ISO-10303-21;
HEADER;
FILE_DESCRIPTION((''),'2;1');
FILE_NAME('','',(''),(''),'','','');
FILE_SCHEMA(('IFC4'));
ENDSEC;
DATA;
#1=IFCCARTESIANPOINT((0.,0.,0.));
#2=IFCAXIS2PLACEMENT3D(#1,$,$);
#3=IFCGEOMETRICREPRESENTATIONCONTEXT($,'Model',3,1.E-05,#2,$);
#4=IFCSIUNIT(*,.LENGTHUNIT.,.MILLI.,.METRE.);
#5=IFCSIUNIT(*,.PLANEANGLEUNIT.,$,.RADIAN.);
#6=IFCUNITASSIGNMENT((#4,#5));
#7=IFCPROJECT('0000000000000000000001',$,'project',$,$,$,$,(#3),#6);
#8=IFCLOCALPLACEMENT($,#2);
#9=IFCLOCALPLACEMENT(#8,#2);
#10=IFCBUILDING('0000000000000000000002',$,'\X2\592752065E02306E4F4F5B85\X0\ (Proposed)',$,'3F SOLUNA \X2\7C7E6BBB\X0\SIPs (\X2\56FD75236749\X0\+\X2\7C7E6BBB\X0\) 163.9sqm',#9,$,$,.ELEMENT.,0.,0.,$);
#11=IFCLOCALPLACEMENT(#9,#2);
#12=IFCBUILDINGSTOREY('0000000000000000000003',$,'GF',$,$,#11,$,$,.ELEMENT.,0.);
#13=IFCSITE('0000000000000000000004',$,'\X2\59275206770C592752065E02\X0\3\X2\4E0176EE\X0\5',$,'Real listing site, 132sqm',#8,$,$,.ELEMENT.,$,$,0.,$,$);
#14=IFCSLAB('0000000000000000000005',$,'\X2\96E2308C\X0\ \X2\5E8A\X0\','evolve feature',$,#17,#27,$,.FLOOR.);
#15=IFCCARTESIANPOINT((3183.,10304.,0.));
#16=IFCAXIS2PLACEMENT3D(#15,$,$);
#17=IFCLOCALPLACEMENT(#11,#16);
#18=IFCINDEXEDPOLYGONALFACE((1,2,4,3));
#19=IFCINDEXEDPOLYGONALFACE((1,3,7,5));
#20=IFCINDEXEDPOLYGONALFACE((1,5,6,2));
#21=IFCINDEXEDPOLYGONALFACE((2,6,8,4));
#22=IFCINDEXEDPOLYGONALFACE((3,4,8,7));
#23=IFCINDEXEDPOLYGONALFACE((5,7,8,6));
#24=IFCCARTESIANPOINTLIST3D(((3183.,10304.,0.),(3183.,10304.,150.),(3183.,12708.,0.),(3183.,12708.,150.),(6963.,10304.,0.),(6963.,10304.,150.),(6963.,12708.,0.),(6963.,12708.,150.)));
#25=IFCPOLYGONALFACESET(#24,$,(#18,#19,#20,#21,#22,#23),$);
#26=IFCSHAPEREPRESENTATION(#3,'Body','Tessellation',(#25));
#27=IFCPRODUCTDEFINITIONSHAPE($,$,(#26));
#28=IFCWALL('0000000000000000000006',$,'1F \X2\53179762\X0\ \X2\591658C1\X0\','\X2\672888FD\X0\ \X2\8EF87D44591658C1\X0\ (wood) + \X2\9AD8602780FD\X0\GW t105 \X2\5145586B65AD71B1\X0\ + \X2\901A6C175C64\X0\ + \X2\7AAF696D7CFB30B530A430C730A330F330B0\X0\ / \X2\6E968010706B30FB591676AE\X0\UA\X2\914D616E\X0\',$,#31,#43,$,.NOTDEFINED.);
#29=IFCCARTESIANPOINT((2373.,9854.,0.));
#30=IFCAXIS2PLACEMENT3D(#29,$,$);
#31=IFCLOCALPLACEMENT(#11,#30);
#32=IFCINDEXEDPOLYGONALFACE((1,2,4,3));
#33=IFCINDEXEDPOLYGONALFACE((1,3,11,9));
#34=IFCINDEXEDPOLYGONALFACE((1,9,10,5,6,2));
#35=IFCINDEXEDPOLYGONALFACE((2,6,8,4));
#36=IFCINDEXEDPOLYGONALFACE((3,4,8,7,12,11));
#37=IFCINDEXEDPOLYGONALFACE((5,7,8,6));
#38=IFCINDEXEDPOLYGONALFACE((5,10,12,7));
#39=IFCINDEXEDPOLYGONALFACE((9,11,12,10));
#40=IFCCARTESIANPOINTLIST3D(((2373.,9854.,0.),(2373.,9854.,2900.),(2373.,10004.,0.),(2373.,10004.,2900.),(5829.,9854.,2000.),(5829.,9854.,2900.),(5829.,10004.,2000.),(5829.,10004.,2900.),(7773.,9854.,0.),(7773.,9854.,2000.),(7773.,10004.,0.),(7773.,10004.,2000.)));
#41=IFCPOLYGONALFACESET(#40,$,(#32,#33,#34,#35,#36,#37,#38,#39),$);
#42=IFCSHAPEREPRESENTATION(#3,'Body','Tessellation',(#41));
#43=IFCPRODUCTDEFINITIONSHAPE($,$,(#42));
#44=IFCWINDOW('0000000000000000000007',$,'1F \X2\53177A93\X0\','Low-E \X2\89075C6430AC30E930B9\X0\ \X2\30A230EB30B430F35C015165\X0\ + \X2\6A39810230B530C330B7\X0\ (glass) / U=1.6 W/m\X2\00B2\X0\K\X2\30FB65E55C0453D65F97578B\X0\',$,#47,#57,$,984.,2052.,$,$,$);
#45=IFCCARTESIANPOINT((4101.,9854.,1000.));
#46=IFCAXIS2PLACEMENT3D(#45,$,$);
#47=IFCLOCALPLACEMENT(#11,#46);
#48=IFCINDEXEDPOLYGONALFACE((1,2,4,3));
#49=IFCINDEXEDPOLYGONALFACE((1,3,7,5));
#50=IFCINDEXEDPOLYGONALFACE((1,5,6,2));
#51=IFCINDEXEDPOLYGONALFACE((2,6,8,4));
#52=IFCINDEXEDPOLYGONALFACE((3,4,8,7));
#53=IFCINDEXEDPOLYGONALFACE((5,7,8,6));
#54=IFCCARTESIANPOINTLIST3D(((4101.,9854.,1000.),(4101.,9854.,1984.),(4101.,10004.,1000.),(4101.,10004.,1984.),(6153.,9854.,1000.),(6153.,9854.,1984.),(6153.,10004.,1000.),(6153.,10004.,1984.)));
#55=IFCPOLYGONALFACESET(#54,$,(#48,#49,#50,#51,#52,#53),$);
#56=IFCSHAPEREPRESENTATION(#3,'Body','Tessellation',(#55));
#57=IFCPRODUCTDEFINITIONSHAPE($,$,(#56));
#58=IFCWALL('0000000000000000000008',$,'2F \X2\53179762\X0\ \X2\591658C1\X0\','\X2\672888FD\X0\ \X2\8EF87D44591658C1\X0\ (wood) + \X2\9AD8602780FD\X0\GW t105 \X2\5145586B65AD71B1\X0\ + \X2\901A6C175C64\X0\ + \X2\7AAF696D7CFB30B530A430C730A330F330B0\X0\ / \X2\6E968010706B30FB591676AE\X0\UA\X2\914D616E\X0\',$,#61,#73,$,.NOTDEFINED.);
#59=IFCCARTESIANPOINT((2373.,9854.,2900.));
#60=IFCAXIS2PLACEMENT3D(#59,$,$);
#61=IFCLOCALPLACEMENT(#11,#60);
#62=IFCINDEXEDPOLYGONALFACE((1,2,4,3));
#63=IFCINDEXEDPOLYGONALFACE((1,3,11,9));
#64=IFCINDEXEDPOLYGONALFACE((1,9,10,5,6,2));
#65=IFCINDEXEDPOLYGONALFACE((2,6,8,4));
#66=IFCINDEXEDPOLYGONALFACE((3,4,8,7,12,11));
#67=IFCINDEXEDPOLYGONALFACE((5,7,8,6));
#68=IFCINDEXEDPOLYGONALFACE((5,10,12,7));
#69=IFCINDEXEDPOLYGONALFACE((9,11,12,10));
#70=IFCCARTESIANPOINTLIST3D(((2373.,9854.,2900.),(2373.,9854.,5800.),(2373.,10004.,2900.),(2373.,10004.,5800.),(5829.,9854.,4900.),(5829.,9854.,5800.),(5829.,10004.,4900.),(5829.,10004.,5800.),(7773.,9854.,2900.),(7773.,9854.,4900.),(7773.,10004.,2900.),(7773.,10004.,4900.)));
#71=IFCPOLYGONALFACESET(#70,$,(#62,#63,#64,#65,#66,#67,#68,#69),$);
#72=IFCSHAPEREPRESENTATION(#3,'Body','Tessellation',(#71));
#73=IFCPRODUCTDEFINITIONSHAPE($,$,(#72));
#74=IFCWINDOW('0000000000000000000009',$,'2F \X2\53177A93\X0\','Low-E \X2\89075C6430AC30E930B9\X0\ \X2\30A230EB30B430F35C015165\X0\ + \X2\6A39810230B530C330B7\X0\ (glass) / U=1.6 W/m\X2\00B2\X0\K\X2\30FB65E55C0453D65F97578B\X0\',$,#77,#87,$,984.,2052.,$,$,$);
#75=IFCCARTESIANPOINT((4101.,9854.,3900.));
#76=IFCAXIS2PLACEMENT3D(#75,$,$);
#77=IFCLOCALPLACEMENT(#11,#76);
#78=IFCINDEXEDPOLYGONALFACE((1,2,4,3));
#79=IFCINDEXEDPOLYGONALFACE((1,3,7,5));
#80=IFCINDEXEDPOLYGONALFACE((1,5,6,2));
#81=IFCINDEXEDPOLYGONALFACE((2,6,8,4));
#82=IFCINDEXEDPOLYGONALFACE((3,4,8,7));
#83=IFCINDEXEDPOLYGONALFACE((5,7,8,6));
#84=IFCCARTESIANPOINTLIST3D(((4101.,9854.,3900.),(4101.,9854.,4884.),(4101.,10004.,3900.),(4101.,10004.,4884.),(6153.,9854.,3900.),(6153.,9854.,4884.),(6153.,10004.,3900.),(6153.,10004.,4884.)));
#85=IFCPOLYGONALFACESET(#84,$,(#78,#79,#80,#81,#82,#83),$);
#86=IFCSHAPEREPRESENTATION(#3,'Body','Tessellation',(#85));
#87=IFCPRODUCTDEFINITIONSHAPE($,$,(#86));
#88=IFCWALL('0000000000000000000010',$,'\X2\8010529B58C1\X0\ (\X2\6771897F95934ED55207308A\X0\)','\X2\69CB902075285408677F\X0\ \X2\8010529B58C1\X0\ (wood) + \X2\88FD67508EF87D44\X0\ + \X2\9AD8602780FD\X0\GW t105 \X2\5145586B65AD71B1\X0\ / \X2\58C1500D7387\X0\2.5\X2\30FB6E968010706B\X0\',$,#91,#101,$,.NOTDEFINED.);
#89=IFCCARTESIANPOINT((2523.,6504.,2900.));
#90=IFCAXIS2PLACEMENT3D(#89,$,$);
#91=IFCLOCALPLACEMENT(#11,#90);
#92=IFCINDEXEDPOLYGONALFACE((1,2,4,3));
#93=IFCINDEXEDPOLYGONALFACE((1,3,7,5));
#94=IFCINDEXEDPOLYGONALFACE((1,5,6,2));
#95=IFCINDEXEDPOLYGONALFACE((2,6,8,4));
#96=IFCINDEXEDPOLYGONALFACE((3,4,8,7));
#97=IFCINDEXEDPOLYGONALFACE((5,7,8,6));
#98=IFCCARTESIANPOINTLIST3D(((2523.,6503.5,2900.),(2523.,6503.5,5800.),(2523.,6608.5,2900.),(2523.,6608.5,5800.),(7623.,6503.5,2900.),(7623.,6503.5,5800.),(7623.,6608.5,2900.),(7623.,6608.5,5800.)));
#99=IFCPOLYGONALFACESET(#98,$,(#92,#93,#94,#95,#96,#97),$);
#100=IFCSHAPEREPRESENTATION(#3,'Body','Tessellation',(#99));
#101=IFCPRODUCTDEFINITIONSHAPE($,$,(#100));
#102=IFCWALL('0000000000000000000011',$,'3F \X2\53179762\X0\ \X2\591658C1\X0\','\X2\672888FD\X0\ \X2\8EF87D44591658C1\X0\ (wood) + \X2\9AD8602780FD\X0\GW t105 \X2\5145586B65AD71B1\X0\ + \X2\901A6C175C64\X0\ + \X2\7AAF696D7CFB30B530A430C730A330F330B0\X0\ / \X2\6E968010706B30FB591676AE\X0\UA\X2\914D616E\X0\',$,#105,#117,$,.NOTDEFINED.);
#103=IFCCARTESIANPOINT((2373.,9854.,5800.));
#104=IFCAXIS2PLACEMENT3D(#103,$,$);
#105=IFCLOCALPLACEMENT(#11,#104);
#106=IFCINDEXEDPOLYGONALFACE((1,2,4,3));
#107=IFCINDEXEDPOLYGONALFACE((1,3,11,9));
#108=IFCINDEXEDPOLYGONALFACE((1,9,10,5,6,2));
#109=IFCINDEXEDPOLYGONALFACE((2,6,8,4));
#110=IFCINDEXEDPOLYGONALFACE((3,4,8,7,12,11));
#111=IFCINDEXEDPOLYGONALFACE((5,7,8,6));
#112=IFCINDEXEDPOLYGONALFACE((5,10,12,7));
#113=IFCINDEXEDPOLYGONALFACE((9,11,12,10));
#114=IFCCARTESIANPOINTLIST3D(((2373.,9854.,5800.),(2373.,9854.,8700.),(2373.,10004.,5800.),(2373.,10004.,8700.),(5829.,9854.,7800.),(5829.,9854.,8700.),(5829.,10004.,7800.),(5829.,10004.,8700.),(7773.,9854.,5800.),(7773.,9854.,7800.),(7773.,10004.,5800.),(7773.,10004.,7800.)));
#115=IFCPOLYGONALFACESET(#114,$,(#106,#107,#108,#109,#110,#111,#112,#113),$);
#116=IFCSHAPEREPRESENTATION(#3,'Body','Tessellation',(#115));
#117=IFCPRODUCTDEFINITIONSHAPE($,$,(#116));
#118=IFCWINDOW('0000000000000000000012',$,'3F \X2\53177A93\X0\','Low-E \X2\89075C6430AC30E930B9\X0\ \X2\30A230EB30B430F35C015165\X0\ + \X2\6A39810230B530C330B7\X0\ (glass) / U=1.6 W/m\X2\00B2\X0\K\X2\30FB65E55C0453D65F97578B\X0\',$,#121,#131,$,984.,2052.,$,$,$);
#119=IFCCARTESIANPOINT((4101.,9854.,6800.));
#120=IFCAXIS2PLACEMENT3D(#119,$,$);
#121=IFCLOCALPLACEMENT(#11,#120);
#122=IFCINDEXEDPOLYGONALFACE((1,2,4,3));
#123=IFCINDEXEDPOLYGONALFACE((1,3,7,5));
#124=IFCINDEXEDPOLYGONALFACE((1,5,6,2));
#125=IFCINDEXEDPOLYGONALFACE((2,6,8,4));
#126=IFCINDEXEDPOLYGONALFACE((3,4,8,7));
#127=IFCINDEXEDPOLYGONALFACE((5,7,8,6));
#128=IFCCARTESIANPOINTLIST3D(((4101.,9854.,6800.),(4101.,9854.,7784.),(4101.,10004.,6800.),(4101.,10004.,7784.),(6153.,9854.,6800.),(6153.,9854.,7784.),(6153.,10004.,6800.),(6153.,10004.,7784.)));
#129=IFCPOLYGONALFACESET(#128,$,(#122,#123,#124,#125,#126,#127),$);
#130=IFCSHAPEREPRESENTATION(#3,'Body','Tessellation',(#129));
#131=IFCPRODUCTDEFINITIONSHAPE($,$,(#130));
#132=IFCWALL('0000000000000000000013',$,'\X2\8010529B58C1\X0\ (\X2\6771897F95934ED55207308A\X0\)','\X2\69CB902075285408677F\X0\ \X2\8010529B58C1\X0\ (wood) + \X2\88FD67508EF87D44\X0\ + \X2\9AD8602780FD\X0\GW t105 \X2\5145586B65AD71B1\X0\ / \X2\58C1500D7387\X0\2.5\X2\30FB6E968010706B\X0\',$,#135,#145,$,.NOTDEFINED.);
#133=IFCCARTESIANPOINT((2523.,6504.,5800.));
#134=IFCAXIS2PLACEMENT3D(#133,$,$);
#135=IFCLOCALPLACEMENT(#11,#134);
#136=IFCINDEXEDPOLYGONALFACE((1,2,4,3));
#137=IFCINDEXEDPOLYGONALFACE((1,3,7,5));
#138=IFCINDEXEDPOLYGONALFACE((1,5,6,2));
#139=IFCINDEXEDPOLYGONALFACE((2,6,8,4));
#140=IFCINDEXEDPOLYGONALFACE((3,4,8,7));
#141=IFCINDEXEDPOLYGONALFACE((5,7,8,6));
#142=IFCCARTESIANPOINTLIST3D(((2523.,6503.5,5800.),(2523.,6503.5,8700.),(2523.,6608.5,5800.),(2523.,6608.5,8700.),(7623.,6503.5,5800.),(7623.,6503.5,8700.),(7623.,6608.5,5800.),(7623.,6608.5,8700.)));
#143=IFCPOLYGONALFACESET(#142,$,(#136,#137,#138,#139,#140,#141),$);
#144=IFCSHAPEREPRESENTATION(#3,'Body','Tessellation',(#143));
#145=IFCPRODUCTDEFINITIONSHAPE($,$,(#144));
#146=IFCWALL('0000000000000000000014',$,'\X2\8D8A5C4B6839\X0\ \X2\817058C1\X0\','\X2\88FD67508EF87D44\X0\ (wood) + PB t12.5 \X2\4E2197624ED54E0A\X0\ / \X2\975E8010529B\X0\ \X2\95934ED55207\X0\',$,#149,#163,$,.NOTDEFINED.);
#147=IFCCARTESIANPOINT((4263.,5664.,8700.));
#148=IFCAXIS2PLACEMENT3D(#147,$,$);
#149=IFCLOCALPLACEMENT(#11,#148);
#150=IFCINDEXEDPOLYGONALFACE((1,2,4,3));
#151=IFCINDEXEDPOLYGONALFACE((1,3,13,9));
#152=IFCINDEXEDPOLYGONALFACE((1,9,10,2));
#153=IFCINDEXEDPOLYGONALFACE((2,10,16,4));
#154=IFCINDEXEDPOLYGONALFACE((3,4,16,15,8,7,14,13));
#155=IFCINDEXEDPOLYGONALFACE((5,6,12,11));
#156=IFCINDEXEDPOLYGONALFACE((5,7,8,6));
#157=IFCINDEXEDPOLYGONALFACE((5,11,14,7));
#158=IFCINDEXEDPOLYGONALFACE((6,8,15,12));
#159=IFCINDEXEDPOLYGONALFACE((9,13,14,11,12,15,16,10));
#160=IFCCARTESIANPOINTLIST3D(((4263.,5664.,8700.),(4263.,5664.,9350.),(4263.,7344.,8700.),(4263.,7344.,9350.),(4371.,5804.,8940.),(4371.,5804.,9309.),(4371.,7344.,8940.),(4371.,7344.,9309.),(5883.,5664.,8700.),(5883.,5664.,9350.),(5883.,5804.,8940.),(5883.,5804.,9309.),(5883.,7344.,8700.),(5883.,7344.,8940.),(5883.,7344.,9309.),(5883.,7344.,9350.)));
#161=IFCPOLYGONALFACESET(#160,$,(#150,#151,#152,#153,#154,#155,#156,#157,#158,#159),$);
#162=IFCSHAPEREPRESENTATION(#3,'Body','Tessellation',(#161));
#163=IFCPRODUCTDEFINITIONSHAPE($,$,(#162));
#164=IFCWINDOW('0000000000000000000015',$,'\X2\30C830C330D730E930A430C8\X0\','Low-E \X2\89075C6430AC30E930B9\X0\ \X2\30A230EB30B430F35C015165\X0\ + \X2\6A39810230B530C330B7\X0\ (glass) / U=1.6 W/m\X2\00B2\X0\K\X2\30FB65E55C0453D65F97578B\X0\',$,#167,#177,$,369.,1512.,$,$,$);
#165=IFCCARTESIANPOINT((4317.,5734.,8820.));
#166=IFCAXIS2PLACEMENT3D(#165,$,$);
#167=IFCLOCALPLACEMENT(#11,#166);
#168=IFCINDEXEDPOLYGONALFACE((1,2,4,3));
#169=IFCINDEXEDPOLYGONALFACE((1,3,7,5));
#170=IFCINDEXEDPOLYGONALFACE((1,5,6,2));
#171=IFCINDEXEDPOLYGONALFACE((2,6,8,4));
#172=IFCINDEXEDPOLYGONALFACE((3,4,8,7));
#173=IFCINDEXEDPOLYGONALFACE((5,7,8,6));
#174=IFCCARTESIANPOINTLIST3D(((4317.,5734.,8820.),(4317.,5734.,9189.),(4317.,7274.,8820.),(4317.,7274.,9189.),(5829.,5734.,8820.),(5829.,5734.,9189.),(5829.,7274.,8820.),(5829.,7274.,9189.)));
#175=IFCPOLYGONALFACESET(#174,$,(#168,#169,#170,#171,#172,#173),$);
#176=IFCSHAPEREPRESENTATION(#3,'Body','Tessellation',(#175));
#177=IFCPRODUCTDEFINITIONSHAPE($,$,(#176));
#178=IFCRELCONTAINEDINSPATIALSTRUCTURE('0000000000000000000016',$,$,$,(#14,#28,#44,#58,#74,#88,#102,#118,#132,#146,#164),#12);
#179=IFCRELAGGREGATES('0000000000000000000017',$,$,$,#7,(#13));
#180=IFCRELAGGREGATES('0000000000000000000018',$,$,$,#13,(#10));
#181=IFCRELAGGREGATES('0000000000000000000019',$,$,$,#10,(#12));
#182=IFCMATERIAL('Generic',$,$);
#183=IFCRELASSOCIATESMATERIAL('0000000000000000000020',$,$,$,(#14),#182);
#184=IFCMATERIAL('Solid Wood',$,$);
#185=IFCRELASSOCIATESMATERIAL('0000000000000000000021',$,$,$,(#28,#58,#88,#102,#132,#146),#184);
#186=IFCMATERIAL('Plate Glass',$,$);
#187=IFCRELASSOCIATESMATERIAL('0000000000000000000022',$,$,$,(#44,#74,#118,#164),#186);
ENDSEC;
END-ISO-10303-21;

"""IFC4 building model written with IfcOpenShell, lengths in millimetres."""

from ifc_helpers import new_model, si_unit, frame, frame_2d, origin, place, context, project, spatial, rectangle, extrude, material, element, fill, save


model = new_model("IFC4")

# Units and contexts
model_context = context("Model", 3, precision=1e-05, world=origin())
ifc_project = project(units=[si_unit("LENGTHUNIT", "METRE", prefix="MILLI"), si_unit("PLANEANGLEUNIT", "RADIAN")], contexts=[model_context])

# Site, building, storey
site_placement = place(None, origin())
site = spatial("IfcSite", under=ifc_project, at=site_placement, Name="大分県大分市3丁目5", ObjectType="Real listing site, 132sqm", CompositionType="ELEMENT", RefElevation=0.0)
building_placement = place(site_placement, origin())
building = spatial("IfcBuilding", under=site, at=building_placement, Name="大分市の住宅 (Proposed)", ObjectType="3F SOLUNA 籾殻SIPs (国産杉+籾殻) 163.9sqm", CompositionType="ELEMENT", ElevationOfRefHeight=0.0, ElevationOfTerrain=0.0)
storey_placement = place(building_placement, origin())
storey = spatial("IfcBuildingStorey", under=building, at=storey_placement, Name="GF", CompositionType="ELEMENT", Elevation=0.0)

# Slab
ifc_material_1 = material(Name="Generic")
slab_placement = place(storey_placement, frame((3183.0, 10304.0, 0.0)))
element("IfcSlab", 1, at=slab_placement, inside=storey, material=ifc_material_1, Name="離れ 床", Description="evolve feature", PredefinedType="FLOOR", context=model_context, shape_type="SweptSolid", body=[
    extrude(rectangle(XDim=3780.0, YDim=2404.0, at=frame_2d((1890.0, 1202.0))), frame((3183.0, 10304.0, 0.0)), (0.0, 0.0, 1.0), 150.0),
])

# Wall, opening, window
ifc_material_2 = material(Name="Solid Wood")
wall_1_placement = place(storey_placement, frame((2373.0, 9854.0, 0.0)))
wall_1 = element("IfcWall", 2, at=wall_1_placement, inside=storey, material=ifc_material_2, Name="1F 北面 外壁", Description="木製 軸組外壁 (wood) + 高性能GW t105 充填断熱 + 通気層 + 窯業系サイディング / 準耐火・外皮UA配慮", PredefinedType="NOTDEFINED", context=model_context, shape_type="SweptSolid", body=[
    extrude(rectangle(XDim=5400.0, YDim=150.0, at=frame_2d((2700.0, 75.0))), frame((2373.0, 9854.0, 0.0)), (0.0, 0.0, 1.0), 2900.0),
])
opening_1_placement = place(storey_placement, frame((4101.0, 9854.0, 1000.0)))
opening_1 = element("IfcOpeningElement", 3, at=opening_1_placement, cuts=wall_1, PredefinedType="NOTDEFINED", context=model_context, shape_type="SweptSolid", body=[
    extrude(rectangle(XDim=2052.0, YDim=150.0, at=frame_2d((1026.0, 75.0))), frame((4101.0, 9854.0, 1000.0)), (0.0, 0.0, 1.0), 984.0),
])
ifc_material_3 = material(Name="Plate Glass")
window_1_placement = place(storey_placement, frame((4101.0, 9854.0, 1000.0)))
window_1 = element("IfcWindow", 4, at=window_1_placement, inside=storey, material=ifc_material_3, Name="1F 北窓", Description="Low-E 複層ガラス アルゴン封入 + 樹脂サッシ (glass) / U=1.6 W/m²K・日射取得型", OverallHeight=984.0, OverallWidth=2052.0, context=model_context, shape_type="SweptSolid", body=[
    extrude(rectangle(XDim=2052.0, YDim=150.0, at=frame_2d((1026.0, 75.0))), frame((4101.0, 9854.0, 1000.0)), (0.0, 0.0, 1.0), 984.0),
])
fill(opening_1, window_1)

# Wall, opening, window
wall_2_placement = place(storey_placement, frame((2373.0, 9854.0, 2900.0)))
wall_2 = element("IfcWall", 5, at=wall_2_placement, inside=storey, material=ifc_material_2, Name="2F 北面 外壁", Description="木製 軸組外壁 (wood) + 高性能GW t105 充填断熱 + 通気層 + 窯業系サイディング / 準耐火・外皮UA配慮", PredefinedType="NOTDEFINED", context=model_context, shape_type="SweptSolid", body=[
    extrude(rectangle(XDim=5400.0, YDim=150.0, at=frame_2d((2700.0, 75.0))), frame((2373.0, 9854.0, 2900.0)), (0.0, 0.0, 1.0), 2900.0),
])
opening_2_placement = place(storey_placement, frame((4101.0, 9854.0, 3900.0)))
opening_2 = element("IfcOpeningElement", 6, at=opening_2_placement, cuts=wall_2, PredefinedType="NOTDEFINED", context=model_context, shape_type="SweptSolid", body=[
    extrude(rectangle(XDim=2052.0, YDim=150.0, at=frame_2d((1026.0, 75.0))), frame((4101.0, 9854.0, 3900.0)), (0.0, 0.0, 1.0), 984.0),
])
window_2_placement = place(storey_placement, frame((4101.0, 9854.0, 3900.0)))
window_2 = element("IfcWindow", 7, at=window_2_placement, inside=storey, material=ifc_material_3, Name="2F 北窓", Description="Low-E 複層ガラス アルゴン封入 + 樹脂サッシ (glass) / U=1.6 W/m²K・日射取得型", OverallHeight=984.0, OverallWidth=2052.0, context=model_context, shape_type="SweptSolid", body=[
    extrude(rectangle(XDim=2052.0, YDim=150.0, at=frame_2d((1026.0, 75.0))), frame((4101.0, 9854.0, 3900.0)), (0.0, 0.0, 1.0), 984.0),
])
fill(opening_2, window_2)

# Wall
wall_3_placement = place(storey_placement, frame((2523.0, 6504.0, 2900.0)))
element("IfcWall", 8, at=wall_3_placement, inside=storey, material=ifc_material_2, Name="耐力壁 (東西間仕切り)", Description="構造用合板 耐力壁 (wood) + 製材軸組 + 高性能GW t105 充填断熱 / 壁倍率2.5・準耐火", PredefinedType="NOTDEFINED", context=model_context, shape_type="SweptSolid", body=[
    extrude(rectangle(XDim=5100.0, YDim=105.0, at=frame_2d((2550.0, 52.0))), frame((2523.0, 6504.0, 2900.0)), (0.0, 0.0, 1.0), 2900.0),
])

# Wall, opening, window
wall_4_placement = place(storey_placement, frame((2373.0, 9854.0, 5800.0)))
wall_4 = element("IfcWall", 9, at=wall_4_placement, inside=storey, material=ifc_material_2, Name="3F 北面 外壁", Description="木製 軸組外壁 (wood) + 高性能GW t105 充填断熱 + 通気層 + 窯業系サイディング / 準耐火・外皮UA配慮", PredefinedType="NOTDEFINED", context=model_context, shape_type="SweptSolid", body=[
    extrude(rectangle(XDim=5400.0, YDim=150.0, at=frame_2d((2700.0, 75.0))), frame((2373.0, 9854.0, 5800.0)), (0.0, 0.0, 1.0), 2900.0),
])
opening_3_placement = place(storey_placement, frame((4101.0, 9854.0, 6800.0)))
opening_3 = element("IfcOpeningElement", 10, at=opening_3_placement, cuts=wall_4, PredefinedType="NOTDEFINED", context=model_context, shape_type="SweptSolid", body=[
    extrude(rectangle(XDim=2052.0, YDim=150.0, at=frame_2d((1026.0, 75.0))), frame((4101.0, 9854.0, 6800.0)), (0.0, 0.0, 1.0), 984.0),
])
window_3_placement = place(storey_placement, frame((4101.0, 9854.0, 6800.0)))
window_3 = element("IfcWindow", 11, at=window_3_placement, inside=storey, material=ifc_material_3, Name="3F 北窓", Description="Low-E 複層ガラス アルゴン封入 + 樹脂サッシ (glass) / U=1.6 W/m²K・日射取得型", OverallHeight=984.0, OverallWidth=2052.0, context=model_context, shape_type="SweptSolid", body=[
    extrude(rectangle(XDim=2052.0, YDim=150.0, at=frame_2d((1026.0, 75.0))), frame((4101.0, 9854.0, 6800.0)), (0.0, 0.0, 1.0), 984.0),
])
fill(opening_3, window_3)

# Wall
wall_5_placement = place(storey_placement, frame((2523.0, 6504.0, 5800.0)))
element("IfcWall", 12, at=wall_5_placement, inside=storey, material=ifc_material_2, Name="耐力壁 (東西間仕切り)", Description="構造用合板 耐力壁 (wood) + 製材軸組 + 高性能GW t105 充填断熱 / 壁倍率2.5・準耐火", PredefinedType="NOTDEFINED", context=model_context, shape_type="SweptSolid", body=[
    extrude(rectangle(XDim=5100.0, YDim=105.0, at=frame_2d((2550.0, 52.0))), frame((2523.0, 6504.0, 5800.0)), (0.0, 0.0, 1.0), 2900.0),
])

# Wall, opening, window
wall_6_placement = place(storey_placement, frame((4263.0, 5664.0, 8700.0)))
wall_6 = element("IfcWall", 13, at=wall_6_placement, inside=storey, material=ifc_material_2, Name="越屋根 腰壁", Description="製材軸組 (wood) + PB t12.5 両面仕上 / 非耐力 間仕切", PredefinedType="NOTDEFINED", context=model_context, shape_type="SweptSolid", body=[
    extrude(rectangle(XDim=1620.0, YDim=1680.0, at=frame_2d((810.0, 840.0))), frame((4263.0, 5664.0, 8700.0)), (0.0, 0.0, 1.0), 650.0),
])
opening_4_placement = place(storey_placement, frame((4317.0, 5734.0, 8820.0)))
opening_4 = element("IfcOpeningElement", 14, at=opening_4_placement, cuts=wall_6, PredefinedType="NOTDEFINED", context=model_context, shape_type="SweptSolid", body=[
    extrude(rectangle(XDim=1512.0, YDim=1540.0, at=frame_2d((756.0, 770.0))), frame((4317.0, 5734.0, 8820.0)), (0.0, 0.0, 1.0), 369.0),
])
window_4_placement = place(storey_placement, frame((4317.0, 5734.0, 8820.0)))
window_4 = element("IfcWindow", 15, at=window_4_placement, inside=storey, material=ifc_material_3, Name="トップライト", Description="Low-E 複層ガラス アルゴン封入 + 樹脂サッシ (glass) / U=1.6 W/m²K・日射取得型", OverallHeight=369.0, OverallWidth=1512.0, context=model_context, shape_type="SweptSolid", body=[
    extrude(rectangle(XDim=1512.0, YDim=1540.0, at=frame_2d((756.0, 770.0))), frame((4317.0, 5734.0, 8820.0)), (0.0, 0.0, 1.0), 369.0),
])
fill(opening_4, window_4)

save(model, "model.ifc")
